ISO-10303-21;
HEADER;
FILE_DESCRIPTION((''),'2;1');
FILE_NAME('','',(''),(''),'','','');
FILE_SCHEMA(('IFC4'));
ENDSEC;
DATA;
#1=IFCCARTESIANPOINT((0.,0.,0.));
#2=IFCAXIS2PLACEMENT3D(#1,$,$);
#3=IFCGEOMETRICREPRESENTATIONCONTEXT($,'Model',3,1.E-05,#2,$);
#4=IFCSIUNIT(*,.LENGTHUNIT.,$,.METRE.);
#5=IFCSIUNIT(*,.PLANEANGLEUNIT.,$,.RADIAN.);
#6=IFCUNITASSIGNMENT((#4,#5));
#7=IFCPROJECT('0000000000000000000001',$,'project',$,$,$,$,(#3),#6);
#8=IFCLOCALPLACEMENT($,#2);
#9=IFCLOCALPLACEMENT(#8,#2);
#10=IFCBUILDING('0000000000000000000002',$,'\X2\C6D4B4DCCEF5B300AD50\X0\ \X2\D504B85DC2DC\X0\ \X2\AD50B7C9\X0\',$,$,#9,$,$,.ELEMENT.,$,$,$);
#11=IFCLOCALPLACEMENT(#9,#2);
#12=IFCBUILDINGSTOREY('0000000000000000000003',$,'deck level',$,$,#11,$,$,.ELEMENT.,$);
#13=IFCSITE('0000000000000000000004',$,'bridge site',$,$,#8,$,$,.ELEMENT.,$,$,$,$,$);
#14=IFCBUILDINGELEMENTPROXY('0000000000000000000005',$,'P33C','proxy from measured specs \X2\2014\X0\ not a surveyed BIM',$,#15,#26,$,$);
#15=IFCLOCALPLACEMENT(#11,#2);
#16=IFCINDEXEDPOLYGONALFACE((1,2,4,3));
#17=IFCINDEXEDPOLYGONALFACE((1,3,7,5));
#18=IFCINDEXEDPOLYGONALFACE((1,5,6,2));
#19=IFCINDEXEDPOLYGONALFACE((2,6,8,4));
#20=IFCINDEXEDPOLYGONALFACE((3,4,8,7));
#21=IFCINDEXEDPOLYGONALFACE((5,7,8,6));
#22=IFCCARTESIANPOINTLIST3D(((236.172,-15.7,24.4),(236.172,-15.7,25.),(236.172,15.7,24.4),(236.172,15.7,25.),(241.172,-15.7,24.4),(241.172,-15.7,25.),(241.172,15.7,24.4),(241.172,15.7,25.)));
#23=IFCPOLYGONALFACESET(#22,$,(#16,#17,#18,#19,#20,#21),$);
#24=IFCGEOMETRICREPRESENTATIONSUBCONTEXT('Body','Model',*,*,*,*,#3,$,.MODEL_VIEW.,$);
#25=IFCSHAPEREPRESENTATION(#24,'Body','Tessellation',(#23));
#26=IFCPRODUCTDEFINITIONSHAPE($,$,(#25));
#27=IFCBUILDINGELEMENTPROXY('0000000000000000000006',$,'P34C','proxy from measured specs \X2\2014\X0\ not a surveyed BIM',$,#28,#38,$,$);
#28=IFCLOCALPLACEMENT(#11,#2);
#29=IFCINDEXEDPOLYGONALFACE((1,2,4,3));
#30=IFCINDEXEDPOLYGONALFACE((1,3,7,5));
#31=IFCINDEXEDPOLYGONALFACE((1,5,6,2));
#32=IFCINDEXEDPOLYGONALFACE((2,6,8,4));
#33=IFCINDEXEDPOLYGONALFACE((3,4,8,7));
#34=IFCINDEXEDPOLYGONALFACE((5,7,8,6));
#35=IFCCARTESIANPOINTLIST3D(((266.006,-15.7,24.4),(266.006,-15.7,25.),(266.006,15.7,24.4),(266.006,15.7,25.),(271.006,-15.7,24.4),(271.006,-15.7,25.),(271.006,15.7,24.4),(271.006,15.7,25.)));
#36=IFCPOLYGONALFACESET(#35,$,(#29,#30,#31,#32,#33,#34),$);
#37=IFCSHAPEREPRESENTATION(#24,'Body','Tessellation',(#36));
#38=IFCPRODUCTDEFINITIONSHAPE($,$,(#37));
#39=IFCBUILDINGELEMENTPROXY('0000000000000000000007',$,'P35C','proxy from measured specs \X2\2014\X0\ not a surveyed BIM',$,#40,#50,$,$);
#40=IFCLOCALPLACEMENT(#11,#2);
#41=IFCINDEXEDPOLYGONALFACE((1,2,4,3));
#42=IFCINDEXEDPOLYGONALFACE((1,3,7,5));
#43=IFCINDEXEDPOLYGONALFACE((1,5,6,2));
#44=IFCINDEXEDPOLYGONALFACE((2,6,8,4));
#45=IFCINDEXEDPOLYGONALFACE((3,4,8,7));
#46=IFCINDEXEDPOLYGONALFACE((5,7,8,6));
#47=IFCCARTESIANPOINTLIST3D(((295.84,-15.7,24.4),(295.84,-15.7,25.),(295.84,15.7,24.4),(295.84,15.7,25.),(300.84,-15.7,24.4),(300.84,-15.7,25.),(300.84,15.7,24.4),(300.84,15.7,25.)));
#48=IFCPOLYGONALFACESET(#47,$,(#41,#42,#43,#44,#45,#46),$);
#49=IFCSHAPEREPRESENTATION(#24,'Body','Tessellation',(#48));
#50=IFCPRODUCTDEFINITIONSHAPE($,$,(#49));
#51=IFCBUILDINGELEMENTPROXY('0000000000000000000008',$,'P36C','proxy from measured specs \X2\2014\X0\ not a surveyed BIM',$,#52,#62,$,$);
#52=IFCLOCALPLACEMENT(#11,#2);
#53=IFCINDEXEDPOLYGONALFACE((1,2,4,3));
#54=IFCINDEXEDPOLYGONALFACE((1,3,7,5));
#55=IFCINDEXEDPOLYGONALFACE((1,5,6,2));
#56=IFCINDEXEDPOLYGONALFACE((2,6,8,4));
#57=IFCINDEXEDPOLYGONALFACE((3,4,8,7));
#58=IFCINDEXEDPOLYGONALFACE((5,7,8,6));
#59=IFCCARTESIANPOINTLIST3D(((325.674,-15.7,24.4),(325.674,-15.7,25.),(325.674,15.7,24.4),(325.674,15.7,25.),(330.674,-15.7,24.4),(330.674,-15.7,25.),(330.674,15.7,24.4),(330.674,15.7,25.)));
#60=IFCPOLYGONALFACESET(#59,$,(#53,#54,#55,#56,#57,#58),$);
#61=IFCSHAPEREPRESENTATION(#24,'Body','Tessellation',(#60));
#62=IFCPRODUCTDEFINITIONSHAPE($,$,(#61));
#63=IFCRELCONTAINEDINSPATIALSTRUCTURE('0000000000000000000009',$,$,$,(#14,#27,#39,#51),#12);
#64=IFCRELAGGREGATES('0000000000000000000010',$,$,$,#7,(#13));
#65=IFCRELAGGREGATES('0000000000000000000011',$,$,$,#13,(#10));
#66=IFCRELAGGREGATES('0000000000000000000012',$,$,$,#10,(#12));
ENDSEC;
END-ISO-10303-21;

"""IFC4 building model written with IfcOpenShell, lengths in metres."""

from ifc_helpers import new_model, si_unit, frame, origin, origin_2d, place, context, subcontext, project, spatial, rectangle, extrude, element, save


model = new_model("IFC4")

# Units and contexts
model_context = context("Model", 3, precision=1e-05, world=origin())
body_context = subcontext(model_context, "Body", "Model", "MODEL_VIEW")
ifc_project = project(units=[si_unit("LENGTHUNIT", "METRE"), si_unit("PLANEANGLEUNIT", "RADIAN")], contexts=[model_context])

# Site, building, storey
site_placement = place(None, origin())
site = spatial("IfcSite", under=ifc_project, at=site_placement, Name="bridge site", CompositionType="ELEMENT")
building_placement = place(site_placement, origin())
building = spatial("IfcBuilding", under=site, at=building_placement, Name="월드컵대교 프록시 교량", CompositionType="ELEMENT")
storey_placement = place(building_placement, origin())
storey = spatial("IfcBuildingStorey", under=building, at=storey_placement, Name="deck level", CompositionType="ELEMENT")

# Building element proxies
for number, where, name in (
    (1, (238.672, 0.0, 24.4), "P33C"),
    (2, (268.506, 0.0, 24.4), "P34C"),
    (3, (298.34, 0.0, 24.4), "P35C"),
    (4, (328.174, 0.0, 24.4), "P36C"),
):
    element("IfcBuildingElementProxy", number, at=place(storey_placement, frame(where)), inside=storey, Name=name, Description="proxy from measured specs — not a surveyed BIM", context=body_context, shape_type="SweptSolid", body=[
        extrude(rectangle(XDim=5.0, YDim=31.4, at=origin_2d()), origin(), (0.0, 0.0, 1.0), 0.6),
    ])

save(model, "model.ifc")
